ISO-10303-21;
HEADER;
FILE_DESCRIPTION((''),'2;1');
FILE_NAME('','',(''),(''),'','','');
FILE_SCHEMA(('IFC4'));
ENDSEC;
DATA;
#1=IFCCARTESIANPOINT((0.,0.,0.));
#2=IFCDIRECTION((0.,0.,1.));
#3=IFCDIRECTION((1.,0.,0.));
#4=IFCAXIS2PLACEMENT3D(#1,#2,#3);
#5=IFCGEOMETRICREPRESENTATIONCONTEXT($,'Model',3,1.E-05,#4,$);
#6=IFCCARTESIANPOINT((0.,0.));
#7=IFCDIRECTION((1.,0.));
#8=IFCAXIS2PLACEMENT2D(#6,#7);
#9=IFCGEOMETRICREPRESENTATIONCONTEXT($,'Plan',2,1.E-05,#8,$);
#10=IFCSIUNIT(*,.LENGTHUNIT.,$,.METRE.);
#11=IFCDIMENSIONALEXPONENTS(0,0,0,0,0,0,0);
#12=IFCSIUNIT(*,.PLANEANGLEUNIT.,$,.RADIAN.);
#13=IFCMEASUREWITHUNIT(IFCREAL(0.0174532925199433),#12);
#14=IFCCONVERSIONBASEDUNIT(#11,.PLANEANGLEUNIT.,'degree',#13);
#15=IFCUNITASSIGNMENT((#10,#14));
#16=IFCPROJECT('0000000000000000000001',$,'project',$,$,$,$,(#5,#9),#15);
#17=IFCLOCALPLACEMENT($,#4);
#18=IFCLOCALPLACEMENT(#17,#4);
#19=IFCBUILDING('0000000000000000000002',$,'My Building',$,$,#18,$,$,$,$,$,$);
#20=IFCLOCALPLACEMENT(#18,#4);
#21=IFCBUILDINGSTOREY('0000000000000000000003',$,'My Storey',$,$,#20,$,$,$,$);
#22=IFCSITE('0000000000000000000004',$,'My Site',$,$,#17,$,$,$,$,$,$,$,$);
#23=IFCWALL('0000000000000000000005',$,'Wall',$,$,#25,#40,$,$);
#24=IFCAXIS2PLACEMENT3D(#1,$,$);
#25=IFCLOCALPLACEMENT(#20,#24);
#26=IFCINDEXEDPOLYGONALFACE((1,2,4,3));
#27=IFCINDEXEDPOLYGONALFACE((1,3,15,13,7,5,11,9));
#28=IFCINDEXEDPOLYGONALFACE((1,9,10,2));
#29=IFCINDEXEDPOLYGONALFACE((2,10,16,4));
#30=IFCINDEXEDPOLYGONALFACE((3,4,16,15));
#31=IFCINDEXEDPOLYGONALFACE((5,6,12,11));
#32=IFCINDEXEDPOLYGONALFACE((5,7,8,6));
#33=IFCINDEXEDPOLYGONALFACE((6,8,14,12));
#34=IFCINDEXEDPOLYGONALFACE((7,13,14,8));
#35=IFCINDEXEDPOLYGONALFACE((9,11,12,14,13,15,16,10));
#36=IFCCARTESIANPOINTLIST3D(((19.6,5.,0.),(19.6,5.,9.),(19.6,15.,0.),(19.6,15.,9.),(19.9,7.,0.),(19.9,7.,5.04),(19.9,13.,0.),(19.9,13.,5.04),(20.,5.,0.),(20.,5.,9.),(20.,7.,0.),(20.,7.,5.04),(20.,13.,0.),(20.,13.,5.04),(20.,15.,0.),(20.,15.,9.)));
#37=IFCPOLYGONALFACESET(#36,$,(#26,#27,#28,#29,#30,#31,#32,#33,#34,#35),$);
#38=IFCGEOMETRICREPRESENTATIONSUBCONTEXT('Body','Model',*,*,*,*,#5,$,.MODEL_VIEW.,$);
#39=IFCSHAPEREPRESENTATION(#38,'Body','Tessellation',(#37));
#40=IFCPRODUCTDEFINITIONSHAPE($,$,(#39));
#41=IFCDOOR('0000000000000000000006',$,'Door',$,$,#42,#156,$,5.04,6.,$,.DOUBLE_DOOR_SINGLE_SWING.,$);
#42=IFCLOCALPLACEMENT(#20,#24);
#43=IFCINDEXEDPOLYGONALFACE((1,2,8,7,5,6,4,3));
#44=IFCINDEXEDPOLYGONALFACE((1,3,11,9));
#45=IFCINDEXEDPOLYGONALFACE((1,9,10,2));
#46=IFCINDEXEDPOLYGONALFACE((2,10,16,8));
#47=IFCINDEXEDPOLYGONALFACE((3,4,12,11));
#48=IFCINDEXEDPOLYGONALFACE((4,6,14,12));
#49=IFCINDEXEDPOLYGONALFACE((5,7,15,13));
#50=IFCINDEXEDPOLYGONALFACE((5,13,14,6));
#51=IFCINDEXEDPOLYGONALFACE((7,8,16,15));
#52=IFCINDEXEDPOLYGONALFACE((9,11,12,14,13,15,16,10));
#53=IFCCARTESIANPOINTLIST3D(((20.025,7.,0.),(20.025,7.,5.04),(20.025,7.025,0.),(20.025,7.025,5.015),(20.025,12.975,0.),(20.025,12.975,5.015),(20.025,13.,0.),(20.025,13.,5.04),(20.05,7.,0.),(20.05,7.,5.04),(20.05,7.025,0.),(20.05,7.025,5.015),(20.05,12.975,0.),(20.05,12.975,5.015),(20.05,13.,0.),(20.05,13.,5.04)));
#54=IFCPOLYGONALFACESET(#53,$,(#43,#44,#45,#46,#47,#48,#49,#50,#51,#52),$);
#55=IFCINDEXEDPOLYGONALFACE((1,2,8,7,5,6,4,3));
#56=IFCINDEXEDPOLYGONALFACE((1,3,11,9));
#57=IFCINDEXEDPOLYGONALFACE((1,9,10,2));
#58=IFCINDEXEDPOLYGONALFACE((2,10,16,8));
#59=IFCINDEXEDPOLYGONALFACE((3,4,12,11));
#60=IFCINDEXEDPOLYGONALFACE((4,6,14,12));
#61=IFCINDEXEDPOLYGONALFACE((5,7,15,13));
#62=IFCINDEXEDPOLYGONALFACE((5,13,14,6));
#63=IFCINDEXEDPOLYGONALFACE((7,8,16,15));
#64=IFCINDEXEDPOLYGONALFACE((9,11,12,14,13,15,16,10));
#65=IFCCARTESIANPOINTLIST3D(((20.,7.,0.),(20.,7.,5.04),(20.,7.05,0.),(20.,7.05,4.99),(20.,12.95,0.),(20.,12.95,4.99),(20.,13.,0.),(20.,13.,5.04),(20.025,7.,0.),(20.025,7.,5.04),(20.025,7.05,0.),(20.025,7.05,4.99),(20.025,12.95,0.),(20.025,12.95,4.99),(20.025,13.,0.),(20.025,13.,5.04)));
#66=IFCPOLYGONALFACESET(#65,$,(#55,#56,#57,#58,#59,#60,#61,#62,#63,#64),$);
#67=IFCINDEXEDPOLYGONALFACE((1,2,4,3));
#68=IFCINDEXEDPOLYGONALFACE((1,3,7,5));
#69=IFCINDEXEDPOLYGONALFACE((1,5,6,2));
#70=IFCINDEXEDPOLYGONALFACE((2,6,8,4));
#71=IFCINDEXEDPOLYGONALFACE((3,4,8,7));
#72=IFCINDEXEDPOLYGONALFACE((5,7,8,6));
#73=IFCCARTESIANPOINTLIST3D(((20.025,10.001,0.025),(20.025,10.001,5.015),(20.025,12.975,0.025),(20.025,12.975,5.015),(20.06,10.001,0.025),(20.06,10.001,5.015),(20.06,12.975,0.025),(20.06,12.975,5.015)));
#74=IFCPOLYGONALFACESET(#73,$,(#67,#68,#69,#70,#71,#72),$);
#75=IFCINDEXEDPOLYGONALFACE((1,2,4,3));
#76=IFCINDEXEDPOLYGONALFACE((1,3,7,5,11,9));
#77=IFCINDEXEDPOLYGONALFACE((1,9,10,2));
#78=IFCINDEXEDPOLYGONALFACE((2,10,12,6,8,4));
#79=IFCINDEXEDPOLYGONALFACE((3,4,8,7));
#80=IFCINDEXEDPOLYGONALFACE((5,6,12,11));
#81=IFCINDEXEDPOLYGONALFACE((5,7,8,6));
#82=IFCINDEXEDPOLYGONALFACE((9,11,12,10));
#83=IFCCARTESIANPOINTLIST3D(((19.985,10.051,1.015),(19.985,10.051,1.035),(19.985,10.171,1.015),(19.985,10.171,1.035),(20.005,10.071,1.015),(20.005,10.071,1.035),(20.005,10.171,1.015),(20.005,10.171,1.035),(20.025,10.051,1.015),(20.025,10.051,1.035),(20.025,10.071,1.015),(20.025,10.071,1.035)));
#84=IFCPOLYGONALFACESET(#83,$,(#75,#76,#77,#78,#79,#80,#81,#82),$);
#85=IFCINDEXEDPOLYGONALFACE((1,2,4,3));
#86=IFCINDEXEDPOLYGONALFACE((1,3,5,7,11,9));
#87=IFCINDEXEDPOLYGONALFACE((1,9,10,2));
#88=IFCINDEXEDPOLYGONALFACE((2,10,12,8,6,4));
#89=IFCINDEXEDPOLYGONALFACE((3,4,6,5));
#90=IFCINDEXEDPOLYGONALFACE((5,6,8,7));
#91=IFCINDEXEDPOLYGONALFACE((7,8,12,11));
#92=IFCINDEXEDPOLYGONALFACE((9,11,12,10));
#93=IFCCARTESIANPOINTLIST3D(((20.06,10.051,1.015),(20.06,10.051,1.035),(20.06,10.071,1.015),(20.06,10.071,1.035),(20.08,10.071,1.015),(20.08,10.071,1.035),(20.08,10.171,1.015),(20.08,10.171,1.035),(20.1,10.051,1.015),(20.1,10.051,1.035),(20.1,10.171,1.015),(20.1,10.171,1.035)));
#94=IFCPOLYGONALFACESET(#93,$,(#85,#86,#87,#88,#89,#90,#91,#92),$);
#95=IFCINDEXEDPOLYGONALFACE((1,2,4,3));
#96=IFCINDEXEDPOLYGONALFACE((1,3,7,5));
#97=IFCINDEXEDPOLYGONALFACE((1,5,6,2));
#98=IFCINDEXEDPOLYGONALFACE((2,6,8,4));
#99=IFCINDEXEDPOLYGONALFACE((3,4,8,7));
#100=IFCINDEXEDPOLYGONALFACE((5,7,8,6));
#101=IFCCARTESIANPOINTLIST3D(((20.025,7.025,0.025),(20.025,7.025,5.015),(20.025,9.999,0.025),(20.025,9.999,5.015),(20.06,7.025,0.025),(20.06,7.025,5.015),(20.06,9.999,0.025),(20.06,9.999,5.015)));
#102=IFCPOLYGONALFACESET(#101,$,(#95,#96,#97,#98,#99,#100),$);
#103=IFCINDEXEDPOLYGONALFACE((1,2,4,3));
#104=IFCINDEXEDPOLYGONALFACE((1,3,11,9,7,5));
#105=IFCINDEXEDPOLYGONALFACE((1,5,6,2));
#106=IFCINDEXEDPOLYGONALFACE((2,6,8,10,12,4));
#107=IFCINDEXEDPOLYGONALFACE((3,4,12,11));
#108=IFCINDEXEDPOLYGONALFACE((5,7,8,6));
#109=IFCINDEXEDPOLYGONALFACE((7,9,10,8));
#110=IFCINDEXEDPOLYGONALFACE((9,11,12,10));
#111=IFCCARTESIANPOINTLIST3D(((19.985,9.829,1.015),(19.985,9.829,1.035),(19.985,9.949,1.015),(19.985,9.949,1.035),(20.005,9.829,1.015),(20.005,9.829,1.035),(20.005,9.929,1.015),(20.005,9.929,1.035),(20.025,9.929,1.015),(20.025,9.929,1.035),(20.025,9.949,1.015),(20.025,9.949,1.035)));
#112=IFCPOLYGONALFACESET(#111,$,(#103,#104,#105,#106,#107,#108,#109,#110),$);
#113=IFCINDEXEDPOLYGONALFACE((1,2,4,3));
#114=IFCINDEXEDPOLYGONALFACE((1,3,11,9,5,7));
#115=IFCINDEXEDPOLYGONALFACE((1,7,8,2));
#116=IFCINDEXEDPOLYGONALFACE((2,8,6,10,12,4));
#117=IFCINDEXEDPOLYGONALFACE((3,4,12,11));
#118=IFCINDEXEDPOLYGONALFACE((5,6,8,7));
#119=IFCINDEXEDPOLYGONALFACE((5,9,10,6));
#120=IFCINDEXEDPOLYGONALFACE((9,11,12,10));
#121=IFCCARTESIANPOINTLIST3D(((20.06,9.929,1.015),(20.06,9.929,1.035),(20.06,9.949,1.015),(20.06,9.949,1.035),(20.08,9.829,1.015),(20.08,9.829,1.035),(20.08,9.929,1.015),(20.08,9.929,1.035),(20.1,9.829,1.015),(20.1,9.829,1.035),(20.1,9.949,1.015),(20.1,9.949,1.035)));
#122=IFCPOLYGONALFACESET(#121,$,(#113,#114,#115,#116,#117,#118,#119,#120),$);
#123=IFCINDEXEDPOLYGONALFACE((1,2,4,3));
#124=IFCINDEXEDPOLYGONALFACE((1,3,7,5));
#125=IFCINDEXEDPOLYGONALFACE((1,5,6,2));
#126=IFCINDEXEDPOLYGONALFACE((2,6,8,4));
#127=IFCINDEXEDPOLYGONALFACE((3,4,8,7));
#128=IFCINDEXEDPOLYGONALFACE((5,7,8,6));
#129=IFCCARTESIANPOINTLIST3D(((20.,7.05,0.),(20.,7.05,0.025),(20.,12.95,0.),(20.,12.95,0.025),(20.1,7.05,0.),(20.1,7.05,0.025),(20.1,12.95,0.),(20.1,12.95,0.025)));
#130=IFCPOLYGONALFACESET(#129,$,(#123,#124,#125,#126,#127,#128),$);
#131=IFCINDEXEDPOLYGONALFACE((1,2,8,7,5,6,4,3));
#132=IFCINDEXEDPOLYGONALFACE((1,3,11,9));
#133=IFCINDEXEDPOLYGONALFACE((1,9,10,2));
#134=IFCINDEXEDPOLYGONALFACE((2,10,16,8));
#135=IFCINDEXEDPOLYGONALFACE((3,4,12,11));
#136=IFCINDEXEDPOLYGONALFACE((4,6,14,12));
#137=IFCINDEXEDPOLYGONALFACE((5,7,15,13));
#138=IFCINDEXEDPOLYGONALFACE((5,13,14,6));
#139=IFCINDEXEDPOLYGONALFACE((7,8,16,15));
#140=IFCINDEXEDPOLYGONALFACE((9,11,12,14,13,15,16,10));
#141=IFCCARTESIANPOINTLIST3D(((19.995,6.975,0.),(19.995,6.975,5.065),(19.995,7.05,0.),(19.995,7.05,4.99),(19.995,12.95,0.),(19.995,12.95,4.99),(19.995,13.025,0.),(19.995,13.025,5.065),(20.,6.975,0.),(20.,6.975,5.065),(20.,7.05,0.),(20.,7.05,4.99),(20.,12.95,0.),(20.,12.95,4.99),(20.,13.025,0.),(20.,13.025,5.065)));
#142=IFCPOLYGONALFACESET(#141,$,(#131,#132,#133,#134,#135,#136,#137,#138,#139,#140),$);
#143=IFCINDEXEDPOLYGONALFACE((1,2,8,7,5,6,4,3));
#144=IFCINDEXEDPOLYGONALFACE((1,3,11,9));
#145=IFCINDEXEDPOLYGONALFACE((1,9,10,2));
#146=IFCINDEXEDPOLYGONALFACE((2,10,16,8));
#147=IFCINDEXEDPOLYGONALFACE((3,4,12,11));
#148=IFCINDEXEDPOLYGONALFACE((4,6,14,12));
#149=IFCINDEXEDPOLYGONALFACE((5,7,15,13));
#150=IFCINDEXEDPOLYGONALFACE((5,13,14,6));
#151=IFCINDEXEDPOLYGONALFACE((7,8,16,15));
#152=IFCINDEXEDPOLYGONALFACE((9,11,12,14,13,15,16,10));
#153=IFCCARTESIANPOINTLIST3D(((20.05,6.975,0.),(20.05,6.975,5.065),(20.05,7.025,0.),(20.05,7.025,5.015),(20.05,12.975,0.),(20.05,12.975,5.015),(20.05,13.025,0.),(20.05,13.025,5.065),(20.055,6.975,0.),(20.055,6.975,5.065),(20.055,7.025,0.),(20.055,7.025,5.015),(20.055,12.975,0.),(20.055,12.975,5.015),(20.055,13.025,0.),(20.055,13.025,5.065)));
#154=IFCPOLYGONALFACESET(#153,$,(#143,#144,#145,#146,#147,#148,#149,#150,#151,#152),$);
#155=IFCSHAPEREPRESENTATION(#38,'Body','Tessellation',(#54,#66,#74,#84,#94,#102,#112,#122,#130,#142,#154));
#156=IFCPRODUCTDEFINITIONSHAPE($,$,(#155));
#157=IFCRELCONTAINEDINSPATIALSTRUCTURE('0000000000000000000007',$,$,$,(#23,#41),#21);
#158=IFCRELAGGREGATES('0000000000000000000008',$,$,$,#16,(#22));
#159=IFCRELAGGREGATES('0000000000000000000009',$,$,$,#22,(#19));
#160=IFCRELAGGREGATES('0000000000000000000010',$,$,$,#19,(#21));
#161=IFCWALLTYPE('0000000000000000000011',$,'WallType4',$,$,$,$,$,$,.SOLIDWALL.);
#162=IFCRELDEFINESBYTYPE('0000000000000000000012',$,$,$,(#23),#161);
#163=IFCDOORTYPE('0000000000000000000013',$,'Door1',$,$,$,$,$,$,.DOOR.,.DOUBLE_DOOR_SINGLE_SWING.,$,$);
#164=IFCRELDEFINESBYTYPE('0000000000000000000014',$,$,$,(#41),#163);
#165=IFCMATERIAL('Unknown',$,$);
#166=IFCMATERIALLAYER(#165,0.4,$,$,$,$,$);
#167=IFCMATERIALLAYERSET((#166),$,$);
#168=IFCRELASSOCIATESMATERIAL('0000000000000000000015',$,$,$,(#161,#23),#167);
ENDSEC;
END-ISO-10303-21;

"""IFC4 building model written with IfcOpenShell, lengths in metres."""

from ifc_helpers import new_model, entity, si_unit, converted_unit, frame, origin_with_axes, origin_2d_with_axis, place, context, subcontext, project, spatial, line, indexed_curve, outline, extrude, shape, source, transform, mapped, material, layer, layer_set, layer_usage, type_object, type_shapes, element, fill, save


model = new_model("IFC4")

# Units and contexts
model_context = context("Model", 3, precision=1e-05, world=origin_with_axes())
plan_context = context("Plan", 2, precision=1e-05, world=origin_2d_with_axis())
body_context_1 = subcontext(model_context, "Body", "Model", "MODEL_VIEW")
body_context_2 = subcontext(plan_context, "Body", "Plan", "PLAN_VIEW")
ifc_project = project(units=[si_unit("LENGTHUNIT", "METRE"), converted_unit("PLANEANGLEUNIT", "degree", entity("IfcReal", 0.0174532925199433), si_unit("PLANEANGLEUNIT", "RADIAN"), dimensions=[0, 0, 0, 0, 0, 0, 0])], contexts=[model_context, plan_context])

# Site, building, storey
site_placement = place(None, origin_with_axes())
site = spatial("IfcSite", under=ifc_project, at=site_placement, Name="My Site")
building_placement = place(site_placement, origin_with_axes())
building = spatial("IfcBuilding", under=site, at=building_placement, Name="My Building")
storey_placement = place(building_placement, origin_with_axes())
storey = spatial("IfcBuildingStorey", under=building, at=storey_placement, Name="My Storey")

# Shared definitions
ifc_material = material(Name="Unknown")

# Wall, opening, door
ifc_layer_1 = layer(ifc_material, 0.4)
ifc_layer_set_1 = layer_set([ifc_layer_1])
wall_type_1 = type_object("IfcWallType", Name="WallType4", PredefinedType="SOLIDWALL", material=ifc_layer_set_1)
ifc_layer_usage_1 = layer_usage(ifc_layer_set_1, "AXIS2", "POSITIVE", 0.0)
wall_1_placement = place(storey_placement, frame((19.6, 15.0, 0.0), z_axis=(0.0, 0.0, 1.0), x_axis=(0.0, -1.0, 0.0)))
wall_1 = element("IfcWall", 1, at=wall_1_placement, inside=storey, type_object=wall_type_1, material=ifc_layer_usage_1, Name="Wall", context=body_context_1, shape_type="SweptSolid", body=[
    extrude(outline(indexed_curve([(0.0, 0.0), (0.0, 0.4), (10.0, 0.4), (10.0, 0.0), (0.0, 0.0)], self_intersect=False)), origin_with_axes(), (0.0, 0.0, 1.0), 9.0),
])
shared_shape_1 = source(origin_with_axes(), body_context_1, "Body", "SweptSolid", [
    extrude(outline(indexed_curve([(0.0, 0.0), (6.0, 0.0), (6.0, 5.04), (0.0, 5.04)], segments=[line(1, 2, 3, 4, 1)])), frame((0.0, -0.1, 0.0), z_axis=(0.0, -1.0, 0.0), x_axis=(1.0, 0.0, 0.0)), (0.0, 0.0, -1.0), 0.6),
])
opening_1_placement = place(wall_1_placement, frame((2.0, 0.4, 0.0), z_axis=(0.0, 0.0, 1.0), x_axis=(1.0, 0.0, 0.0)))
opening_1 = element("IfcOpeningElement", 2, at=opening_1_placement, cuts=wall_1, PredefinedType="OPENING", context=body_context_1, shape_type="MappedRepresentation", body=[
    mapped(shared_shape_1, transform((0.0, 0.0, 0.0), x_axis=(1.0, 0.0, 0.0), y_axis=(0.0, 1.0, 0.0), z_axis=(0.0, 0.0, 1.0), scale=1.0)),
])
door_type_1 = type_object("IfcDoorType", Name="Door1", OperationType="DOUBLE_DOOR_SINGLE_SWING", PredefinedType="DOOR")
shared_shape_2 = source(origin_with_axes(), body_context_1, "Body", "SweptSolid", [
    extrude(outline(indexed_curve([(0.0, 0.0), (0.0, 5.04), (6.0, 5.04), (6.0, 0.0), (5.975, 0.0), (5.975, 5.015), (0.025, 5.015), (0.025, 0.0)], segments=[line(1, 2, 3, 4, 5, 6, 7, 8, 1)])), frame((0.0, 0.025, 0.0), z_axis=(0.0, -1.0, 0.0), x_axis=(1.0, 0.0, 0.0)), (0.0, 0.0, -1.0), 0.025),
    extrude(outline(indexed_curve([(0.0, 0.0), (0.0, 5.04), (6.0, 5.04), (6.0, 0.0), (5.95, 0.0), (5.95, 4.99), (0.05, 4.99), (0.05, 0.0)], segments=[line(1, 2, 3, 4, 5, 6, 7, 8, 1)])), frame((0.0, 0.0, 0.0), z_axis=(0.0, -1.0, 0.0), x_axis=(1.0, 0.0, 0.0)), (0.0, 0.0, -1.0), 0.025),
    extrude(outline(indexed_curve([(0.0, 0.0), (2.974, 0.0), (2.974, 0.035), (0.0, 0.035)], segments=[line(1, 2, 3, 4, 1)])), frame((0.025, 0.025, 0.025), z_axis=(0.0, 0.0, 1.0), x_axis=(1.0, 0.0, 0.0)), (0.0, 0.0, 1.0), 4.99),
    extrude(outline(indexed_curve([(0.0, 0.0), (0.0, -0.04), (-0.12, -0.04), (-0.12, -0.02), (-0.02, -0.02), (-0.02, 0.0)], segments=[line(1, 2, 3, 4, 5, 6, 1)])), frame((2.949, 0.025, 1.015), z_axis=(0.0, 0.0, 1.0), x_axis=(1.0, 0.0, 0.0)), (0.0, 0.0, 1.0), 0.02),
    extrude(outline(indexed_curve([(0.0, 0.0), (0.0, 0.04), (-0.12, 0.04), (-0.12, 0.02), (-0.02, 0.02), (-0.02, 0.0)], segments=[line(1, 2, 3, 4, 5, 6, 1)])), frame((2.949, 0.06, 1.015), z_axis=(0.0, 0.0, 1.0), x_axis=(1.0, 0.0, 0.0)), (0.0, 0.0, 1.0), 0.02),
    extrude(outline(indexed_curve([(0.0, 0.0), (-2.974, 0.0), (-2.974, 0.035), (0.0, 0.035)], segments=[line(1, 2, 3, 4, 1)])), frame((5.975, 0.025, 0.025), z_axis=(0.0, 0.0, 1.0), x_axis=(1.0, 0.0, 0.0)), (0.0, 0.0, 1.0), 4.99),
    extrude(outline(indexed_curve([(0.0, 0.0), (0.0, -0.04), (0.12, -0.04), (0.12, -0.02), (0.02, -0.02), (0.02, 0.0)], segments=[line(1, 2, 3, 4, 5, 6, 1)])), frame((3.051, 0.025, 1.015), z_axis=(0.0, 0.0, 1.0), x_axis=(1.0, 0.0, 0.0)), (0.0, 0.0, 1.0), 0.02),
    extrude(outline(indexed_curve([(0.0, 0.0), (0.0, 0.04), (0.12, 0.04), (0.12, 0.02), (0.02, 0.02), (0.02, 0.0)], segments=[line(1, 2, 3, 4, 5, 6, 1)])), frame((3.051, 0.06, 1.015), z_axis=(0.0, 0.0, 1.0), x_axis=(1.0, 0.0, 0.0)), (0.0, 0.0, 1.0), 0.02),
    extrude(outline(indexed_curve([(0.0, 0.0), (5.9, 0.0), (5.9, 0.1), (0.0, 0.1)], segments=[line(1, 2, 3, 4, 1)])), frame((0.05, 0.0, 0.0), z_axis=(0.0, 0.0, 1.0), x_axis=(1.0, 0.0, 0.0)), (0.0, 0.0, 1.0), 0.025),
    extrude(outline(indexed_curve([(0.0, 0.0), (0.0, 5.065), (6.05, 5.065), (6.05, 0.0), (5.975, 0.0), (5.975, 4.99), (0.075, 4.99), (0.075, 0.0)], segments=[line(1, 2, 3, 4, 5, 6, 7, 8, 1)])), frame((-0.025, -0.005, 0.0), z_axis=(0.0, -1.0, 0.0), x_axis=(1.0, 0.0, 0.0)), (0.0, 0.0, -1.0), 0.005),
    extrude(outline(indexed_curve([(0.0, 0.0), (0.0, 5.065), (6.05, 5.065), (6.05, 0.0), (6.0, 0.0), (6.0, 5.015), (0.05, 5.015), (0.05, 0.0)], segments=[line(1, 2, 3, 4, 5, 6, 7, 8, 1)])), frame((-0.025, 0.05, 0.0), z_axis=(0.0, -1.0, 0.0), x_axis=(1.0, 0.0, 0.0)), (0.0, 0.0, -1.0), 0.005),
])
shared_shape_3 = source(origin_with_axes(), body_context_2, "Body", "Curve2D", [
    entity("IfcIndexedPolyCurve", entity("IfcCartesianPointList2D", [[0.0, 0.0], [0.0, 0.05], [0.025, 0.05], [0.025, 0.025], [0.05, 0.025], [0.05, 0.0]]), [entity("IfcLineIndex", [1, 2, 3, 4, 5, 6, 1])]),
    entity("IfcIndexedPolyCurve", entity("IfcCartesianPointList2D", [[6.0, 0.0], [6.0, 0.05], [5.975, 0.05], [5.975, 0.025], [5.95, 0.025], [5.95, 0.0]]), [entity("IfcLineIndex", [1, 2, 3, 4, 5, 6, 1])]),
    entity("IfcTrimmedCurve", entity("IfcEllipse", entity("IfcAxis2Placement2D", entity("IfcCartesianPoint", [0.06, 0.05]), entity("IfcDirection", [1.0, 0.0])), 2.94, 2.975), [entity("IfcCartesianPoint", [3.0, 0.05])], [entity("IfcCartesianPoint", [0.06, 3.025])], True, "CARTESIAN"),
    entity("IfcIndexedPolyCurve", entity("IfcCartesianPointList2D", [[0.025, 0.05], [0.06, 0.05], [0.06, 3.025], [0.025, 3.025]]), [entity("IfcLineIndex", [1, 2, 3, 4, 1])]),
    entity("IfcTrimmedCurve", entity("IfcEllipse", entity("IfcAxis2Placement2D", entity("IfcCartesianPoint", [5.94, 0.05]), entity("IfcDirection", [1.0, 0.0])), 2.94, 2.975), [entity("IfcCartesianPoint", [5.94, 3.025])], [entity("IfcCartesianPoint", [3.0, 0.05])], True, "CARTESIAN"),
    entity("IfcIndexedPolyCurve", entity("IfcCartesianPointList2D", [[5.975, 0.05], [5.94, 0.05], [5.94, 3.025], [5.975, 3.025]]), [entity("IfcLineIndex", [1, 2, 3, 4, 1])]),
])
type_shapes(door_type_1, [shared_shape_2, shared_shape_3])
door_1_placement = place(opening_1_placement, frame((0.0, 0.0, 0.0), z_axis=(0.0, 0.0, 1.0), x_axis=(1.0, 0.0, 0.0)))
door_1 = element("IfcDoor", 3, at=door_1_placement, inside=storey, type_object=door_type_1, Name="Door", OperationType="DOUBLE_DOOR_SINGLE_SWING", OverallHeight=5.04, OverallWidth=6.0, shapes=[
    shape(body_context_1, "Body", "MappedRepresentation", [mapped(shared_shape_2, transform((0.0, 0.0, 0.0), x_axis=(1.0, 0.0, 0.0), y_axis=(0.0, 1.0, 0.0), z_axis=(0.0, 0.0, 1.0), scale=1.0))]),
    shape(body_context_2, "Body", "MappedRepresentation", [mapped(shared_shape_3, transform((0.0, 0.0, 0.0), x_axis=(1.0, 0.0, 0.0), y_axis=(0.0, 1.0, 0.0), z_axis=(0.0, 0.0, 1.0), scale=1.0))]),
])
fill(opening_1, door_1)

save(model, "model.ifc")
